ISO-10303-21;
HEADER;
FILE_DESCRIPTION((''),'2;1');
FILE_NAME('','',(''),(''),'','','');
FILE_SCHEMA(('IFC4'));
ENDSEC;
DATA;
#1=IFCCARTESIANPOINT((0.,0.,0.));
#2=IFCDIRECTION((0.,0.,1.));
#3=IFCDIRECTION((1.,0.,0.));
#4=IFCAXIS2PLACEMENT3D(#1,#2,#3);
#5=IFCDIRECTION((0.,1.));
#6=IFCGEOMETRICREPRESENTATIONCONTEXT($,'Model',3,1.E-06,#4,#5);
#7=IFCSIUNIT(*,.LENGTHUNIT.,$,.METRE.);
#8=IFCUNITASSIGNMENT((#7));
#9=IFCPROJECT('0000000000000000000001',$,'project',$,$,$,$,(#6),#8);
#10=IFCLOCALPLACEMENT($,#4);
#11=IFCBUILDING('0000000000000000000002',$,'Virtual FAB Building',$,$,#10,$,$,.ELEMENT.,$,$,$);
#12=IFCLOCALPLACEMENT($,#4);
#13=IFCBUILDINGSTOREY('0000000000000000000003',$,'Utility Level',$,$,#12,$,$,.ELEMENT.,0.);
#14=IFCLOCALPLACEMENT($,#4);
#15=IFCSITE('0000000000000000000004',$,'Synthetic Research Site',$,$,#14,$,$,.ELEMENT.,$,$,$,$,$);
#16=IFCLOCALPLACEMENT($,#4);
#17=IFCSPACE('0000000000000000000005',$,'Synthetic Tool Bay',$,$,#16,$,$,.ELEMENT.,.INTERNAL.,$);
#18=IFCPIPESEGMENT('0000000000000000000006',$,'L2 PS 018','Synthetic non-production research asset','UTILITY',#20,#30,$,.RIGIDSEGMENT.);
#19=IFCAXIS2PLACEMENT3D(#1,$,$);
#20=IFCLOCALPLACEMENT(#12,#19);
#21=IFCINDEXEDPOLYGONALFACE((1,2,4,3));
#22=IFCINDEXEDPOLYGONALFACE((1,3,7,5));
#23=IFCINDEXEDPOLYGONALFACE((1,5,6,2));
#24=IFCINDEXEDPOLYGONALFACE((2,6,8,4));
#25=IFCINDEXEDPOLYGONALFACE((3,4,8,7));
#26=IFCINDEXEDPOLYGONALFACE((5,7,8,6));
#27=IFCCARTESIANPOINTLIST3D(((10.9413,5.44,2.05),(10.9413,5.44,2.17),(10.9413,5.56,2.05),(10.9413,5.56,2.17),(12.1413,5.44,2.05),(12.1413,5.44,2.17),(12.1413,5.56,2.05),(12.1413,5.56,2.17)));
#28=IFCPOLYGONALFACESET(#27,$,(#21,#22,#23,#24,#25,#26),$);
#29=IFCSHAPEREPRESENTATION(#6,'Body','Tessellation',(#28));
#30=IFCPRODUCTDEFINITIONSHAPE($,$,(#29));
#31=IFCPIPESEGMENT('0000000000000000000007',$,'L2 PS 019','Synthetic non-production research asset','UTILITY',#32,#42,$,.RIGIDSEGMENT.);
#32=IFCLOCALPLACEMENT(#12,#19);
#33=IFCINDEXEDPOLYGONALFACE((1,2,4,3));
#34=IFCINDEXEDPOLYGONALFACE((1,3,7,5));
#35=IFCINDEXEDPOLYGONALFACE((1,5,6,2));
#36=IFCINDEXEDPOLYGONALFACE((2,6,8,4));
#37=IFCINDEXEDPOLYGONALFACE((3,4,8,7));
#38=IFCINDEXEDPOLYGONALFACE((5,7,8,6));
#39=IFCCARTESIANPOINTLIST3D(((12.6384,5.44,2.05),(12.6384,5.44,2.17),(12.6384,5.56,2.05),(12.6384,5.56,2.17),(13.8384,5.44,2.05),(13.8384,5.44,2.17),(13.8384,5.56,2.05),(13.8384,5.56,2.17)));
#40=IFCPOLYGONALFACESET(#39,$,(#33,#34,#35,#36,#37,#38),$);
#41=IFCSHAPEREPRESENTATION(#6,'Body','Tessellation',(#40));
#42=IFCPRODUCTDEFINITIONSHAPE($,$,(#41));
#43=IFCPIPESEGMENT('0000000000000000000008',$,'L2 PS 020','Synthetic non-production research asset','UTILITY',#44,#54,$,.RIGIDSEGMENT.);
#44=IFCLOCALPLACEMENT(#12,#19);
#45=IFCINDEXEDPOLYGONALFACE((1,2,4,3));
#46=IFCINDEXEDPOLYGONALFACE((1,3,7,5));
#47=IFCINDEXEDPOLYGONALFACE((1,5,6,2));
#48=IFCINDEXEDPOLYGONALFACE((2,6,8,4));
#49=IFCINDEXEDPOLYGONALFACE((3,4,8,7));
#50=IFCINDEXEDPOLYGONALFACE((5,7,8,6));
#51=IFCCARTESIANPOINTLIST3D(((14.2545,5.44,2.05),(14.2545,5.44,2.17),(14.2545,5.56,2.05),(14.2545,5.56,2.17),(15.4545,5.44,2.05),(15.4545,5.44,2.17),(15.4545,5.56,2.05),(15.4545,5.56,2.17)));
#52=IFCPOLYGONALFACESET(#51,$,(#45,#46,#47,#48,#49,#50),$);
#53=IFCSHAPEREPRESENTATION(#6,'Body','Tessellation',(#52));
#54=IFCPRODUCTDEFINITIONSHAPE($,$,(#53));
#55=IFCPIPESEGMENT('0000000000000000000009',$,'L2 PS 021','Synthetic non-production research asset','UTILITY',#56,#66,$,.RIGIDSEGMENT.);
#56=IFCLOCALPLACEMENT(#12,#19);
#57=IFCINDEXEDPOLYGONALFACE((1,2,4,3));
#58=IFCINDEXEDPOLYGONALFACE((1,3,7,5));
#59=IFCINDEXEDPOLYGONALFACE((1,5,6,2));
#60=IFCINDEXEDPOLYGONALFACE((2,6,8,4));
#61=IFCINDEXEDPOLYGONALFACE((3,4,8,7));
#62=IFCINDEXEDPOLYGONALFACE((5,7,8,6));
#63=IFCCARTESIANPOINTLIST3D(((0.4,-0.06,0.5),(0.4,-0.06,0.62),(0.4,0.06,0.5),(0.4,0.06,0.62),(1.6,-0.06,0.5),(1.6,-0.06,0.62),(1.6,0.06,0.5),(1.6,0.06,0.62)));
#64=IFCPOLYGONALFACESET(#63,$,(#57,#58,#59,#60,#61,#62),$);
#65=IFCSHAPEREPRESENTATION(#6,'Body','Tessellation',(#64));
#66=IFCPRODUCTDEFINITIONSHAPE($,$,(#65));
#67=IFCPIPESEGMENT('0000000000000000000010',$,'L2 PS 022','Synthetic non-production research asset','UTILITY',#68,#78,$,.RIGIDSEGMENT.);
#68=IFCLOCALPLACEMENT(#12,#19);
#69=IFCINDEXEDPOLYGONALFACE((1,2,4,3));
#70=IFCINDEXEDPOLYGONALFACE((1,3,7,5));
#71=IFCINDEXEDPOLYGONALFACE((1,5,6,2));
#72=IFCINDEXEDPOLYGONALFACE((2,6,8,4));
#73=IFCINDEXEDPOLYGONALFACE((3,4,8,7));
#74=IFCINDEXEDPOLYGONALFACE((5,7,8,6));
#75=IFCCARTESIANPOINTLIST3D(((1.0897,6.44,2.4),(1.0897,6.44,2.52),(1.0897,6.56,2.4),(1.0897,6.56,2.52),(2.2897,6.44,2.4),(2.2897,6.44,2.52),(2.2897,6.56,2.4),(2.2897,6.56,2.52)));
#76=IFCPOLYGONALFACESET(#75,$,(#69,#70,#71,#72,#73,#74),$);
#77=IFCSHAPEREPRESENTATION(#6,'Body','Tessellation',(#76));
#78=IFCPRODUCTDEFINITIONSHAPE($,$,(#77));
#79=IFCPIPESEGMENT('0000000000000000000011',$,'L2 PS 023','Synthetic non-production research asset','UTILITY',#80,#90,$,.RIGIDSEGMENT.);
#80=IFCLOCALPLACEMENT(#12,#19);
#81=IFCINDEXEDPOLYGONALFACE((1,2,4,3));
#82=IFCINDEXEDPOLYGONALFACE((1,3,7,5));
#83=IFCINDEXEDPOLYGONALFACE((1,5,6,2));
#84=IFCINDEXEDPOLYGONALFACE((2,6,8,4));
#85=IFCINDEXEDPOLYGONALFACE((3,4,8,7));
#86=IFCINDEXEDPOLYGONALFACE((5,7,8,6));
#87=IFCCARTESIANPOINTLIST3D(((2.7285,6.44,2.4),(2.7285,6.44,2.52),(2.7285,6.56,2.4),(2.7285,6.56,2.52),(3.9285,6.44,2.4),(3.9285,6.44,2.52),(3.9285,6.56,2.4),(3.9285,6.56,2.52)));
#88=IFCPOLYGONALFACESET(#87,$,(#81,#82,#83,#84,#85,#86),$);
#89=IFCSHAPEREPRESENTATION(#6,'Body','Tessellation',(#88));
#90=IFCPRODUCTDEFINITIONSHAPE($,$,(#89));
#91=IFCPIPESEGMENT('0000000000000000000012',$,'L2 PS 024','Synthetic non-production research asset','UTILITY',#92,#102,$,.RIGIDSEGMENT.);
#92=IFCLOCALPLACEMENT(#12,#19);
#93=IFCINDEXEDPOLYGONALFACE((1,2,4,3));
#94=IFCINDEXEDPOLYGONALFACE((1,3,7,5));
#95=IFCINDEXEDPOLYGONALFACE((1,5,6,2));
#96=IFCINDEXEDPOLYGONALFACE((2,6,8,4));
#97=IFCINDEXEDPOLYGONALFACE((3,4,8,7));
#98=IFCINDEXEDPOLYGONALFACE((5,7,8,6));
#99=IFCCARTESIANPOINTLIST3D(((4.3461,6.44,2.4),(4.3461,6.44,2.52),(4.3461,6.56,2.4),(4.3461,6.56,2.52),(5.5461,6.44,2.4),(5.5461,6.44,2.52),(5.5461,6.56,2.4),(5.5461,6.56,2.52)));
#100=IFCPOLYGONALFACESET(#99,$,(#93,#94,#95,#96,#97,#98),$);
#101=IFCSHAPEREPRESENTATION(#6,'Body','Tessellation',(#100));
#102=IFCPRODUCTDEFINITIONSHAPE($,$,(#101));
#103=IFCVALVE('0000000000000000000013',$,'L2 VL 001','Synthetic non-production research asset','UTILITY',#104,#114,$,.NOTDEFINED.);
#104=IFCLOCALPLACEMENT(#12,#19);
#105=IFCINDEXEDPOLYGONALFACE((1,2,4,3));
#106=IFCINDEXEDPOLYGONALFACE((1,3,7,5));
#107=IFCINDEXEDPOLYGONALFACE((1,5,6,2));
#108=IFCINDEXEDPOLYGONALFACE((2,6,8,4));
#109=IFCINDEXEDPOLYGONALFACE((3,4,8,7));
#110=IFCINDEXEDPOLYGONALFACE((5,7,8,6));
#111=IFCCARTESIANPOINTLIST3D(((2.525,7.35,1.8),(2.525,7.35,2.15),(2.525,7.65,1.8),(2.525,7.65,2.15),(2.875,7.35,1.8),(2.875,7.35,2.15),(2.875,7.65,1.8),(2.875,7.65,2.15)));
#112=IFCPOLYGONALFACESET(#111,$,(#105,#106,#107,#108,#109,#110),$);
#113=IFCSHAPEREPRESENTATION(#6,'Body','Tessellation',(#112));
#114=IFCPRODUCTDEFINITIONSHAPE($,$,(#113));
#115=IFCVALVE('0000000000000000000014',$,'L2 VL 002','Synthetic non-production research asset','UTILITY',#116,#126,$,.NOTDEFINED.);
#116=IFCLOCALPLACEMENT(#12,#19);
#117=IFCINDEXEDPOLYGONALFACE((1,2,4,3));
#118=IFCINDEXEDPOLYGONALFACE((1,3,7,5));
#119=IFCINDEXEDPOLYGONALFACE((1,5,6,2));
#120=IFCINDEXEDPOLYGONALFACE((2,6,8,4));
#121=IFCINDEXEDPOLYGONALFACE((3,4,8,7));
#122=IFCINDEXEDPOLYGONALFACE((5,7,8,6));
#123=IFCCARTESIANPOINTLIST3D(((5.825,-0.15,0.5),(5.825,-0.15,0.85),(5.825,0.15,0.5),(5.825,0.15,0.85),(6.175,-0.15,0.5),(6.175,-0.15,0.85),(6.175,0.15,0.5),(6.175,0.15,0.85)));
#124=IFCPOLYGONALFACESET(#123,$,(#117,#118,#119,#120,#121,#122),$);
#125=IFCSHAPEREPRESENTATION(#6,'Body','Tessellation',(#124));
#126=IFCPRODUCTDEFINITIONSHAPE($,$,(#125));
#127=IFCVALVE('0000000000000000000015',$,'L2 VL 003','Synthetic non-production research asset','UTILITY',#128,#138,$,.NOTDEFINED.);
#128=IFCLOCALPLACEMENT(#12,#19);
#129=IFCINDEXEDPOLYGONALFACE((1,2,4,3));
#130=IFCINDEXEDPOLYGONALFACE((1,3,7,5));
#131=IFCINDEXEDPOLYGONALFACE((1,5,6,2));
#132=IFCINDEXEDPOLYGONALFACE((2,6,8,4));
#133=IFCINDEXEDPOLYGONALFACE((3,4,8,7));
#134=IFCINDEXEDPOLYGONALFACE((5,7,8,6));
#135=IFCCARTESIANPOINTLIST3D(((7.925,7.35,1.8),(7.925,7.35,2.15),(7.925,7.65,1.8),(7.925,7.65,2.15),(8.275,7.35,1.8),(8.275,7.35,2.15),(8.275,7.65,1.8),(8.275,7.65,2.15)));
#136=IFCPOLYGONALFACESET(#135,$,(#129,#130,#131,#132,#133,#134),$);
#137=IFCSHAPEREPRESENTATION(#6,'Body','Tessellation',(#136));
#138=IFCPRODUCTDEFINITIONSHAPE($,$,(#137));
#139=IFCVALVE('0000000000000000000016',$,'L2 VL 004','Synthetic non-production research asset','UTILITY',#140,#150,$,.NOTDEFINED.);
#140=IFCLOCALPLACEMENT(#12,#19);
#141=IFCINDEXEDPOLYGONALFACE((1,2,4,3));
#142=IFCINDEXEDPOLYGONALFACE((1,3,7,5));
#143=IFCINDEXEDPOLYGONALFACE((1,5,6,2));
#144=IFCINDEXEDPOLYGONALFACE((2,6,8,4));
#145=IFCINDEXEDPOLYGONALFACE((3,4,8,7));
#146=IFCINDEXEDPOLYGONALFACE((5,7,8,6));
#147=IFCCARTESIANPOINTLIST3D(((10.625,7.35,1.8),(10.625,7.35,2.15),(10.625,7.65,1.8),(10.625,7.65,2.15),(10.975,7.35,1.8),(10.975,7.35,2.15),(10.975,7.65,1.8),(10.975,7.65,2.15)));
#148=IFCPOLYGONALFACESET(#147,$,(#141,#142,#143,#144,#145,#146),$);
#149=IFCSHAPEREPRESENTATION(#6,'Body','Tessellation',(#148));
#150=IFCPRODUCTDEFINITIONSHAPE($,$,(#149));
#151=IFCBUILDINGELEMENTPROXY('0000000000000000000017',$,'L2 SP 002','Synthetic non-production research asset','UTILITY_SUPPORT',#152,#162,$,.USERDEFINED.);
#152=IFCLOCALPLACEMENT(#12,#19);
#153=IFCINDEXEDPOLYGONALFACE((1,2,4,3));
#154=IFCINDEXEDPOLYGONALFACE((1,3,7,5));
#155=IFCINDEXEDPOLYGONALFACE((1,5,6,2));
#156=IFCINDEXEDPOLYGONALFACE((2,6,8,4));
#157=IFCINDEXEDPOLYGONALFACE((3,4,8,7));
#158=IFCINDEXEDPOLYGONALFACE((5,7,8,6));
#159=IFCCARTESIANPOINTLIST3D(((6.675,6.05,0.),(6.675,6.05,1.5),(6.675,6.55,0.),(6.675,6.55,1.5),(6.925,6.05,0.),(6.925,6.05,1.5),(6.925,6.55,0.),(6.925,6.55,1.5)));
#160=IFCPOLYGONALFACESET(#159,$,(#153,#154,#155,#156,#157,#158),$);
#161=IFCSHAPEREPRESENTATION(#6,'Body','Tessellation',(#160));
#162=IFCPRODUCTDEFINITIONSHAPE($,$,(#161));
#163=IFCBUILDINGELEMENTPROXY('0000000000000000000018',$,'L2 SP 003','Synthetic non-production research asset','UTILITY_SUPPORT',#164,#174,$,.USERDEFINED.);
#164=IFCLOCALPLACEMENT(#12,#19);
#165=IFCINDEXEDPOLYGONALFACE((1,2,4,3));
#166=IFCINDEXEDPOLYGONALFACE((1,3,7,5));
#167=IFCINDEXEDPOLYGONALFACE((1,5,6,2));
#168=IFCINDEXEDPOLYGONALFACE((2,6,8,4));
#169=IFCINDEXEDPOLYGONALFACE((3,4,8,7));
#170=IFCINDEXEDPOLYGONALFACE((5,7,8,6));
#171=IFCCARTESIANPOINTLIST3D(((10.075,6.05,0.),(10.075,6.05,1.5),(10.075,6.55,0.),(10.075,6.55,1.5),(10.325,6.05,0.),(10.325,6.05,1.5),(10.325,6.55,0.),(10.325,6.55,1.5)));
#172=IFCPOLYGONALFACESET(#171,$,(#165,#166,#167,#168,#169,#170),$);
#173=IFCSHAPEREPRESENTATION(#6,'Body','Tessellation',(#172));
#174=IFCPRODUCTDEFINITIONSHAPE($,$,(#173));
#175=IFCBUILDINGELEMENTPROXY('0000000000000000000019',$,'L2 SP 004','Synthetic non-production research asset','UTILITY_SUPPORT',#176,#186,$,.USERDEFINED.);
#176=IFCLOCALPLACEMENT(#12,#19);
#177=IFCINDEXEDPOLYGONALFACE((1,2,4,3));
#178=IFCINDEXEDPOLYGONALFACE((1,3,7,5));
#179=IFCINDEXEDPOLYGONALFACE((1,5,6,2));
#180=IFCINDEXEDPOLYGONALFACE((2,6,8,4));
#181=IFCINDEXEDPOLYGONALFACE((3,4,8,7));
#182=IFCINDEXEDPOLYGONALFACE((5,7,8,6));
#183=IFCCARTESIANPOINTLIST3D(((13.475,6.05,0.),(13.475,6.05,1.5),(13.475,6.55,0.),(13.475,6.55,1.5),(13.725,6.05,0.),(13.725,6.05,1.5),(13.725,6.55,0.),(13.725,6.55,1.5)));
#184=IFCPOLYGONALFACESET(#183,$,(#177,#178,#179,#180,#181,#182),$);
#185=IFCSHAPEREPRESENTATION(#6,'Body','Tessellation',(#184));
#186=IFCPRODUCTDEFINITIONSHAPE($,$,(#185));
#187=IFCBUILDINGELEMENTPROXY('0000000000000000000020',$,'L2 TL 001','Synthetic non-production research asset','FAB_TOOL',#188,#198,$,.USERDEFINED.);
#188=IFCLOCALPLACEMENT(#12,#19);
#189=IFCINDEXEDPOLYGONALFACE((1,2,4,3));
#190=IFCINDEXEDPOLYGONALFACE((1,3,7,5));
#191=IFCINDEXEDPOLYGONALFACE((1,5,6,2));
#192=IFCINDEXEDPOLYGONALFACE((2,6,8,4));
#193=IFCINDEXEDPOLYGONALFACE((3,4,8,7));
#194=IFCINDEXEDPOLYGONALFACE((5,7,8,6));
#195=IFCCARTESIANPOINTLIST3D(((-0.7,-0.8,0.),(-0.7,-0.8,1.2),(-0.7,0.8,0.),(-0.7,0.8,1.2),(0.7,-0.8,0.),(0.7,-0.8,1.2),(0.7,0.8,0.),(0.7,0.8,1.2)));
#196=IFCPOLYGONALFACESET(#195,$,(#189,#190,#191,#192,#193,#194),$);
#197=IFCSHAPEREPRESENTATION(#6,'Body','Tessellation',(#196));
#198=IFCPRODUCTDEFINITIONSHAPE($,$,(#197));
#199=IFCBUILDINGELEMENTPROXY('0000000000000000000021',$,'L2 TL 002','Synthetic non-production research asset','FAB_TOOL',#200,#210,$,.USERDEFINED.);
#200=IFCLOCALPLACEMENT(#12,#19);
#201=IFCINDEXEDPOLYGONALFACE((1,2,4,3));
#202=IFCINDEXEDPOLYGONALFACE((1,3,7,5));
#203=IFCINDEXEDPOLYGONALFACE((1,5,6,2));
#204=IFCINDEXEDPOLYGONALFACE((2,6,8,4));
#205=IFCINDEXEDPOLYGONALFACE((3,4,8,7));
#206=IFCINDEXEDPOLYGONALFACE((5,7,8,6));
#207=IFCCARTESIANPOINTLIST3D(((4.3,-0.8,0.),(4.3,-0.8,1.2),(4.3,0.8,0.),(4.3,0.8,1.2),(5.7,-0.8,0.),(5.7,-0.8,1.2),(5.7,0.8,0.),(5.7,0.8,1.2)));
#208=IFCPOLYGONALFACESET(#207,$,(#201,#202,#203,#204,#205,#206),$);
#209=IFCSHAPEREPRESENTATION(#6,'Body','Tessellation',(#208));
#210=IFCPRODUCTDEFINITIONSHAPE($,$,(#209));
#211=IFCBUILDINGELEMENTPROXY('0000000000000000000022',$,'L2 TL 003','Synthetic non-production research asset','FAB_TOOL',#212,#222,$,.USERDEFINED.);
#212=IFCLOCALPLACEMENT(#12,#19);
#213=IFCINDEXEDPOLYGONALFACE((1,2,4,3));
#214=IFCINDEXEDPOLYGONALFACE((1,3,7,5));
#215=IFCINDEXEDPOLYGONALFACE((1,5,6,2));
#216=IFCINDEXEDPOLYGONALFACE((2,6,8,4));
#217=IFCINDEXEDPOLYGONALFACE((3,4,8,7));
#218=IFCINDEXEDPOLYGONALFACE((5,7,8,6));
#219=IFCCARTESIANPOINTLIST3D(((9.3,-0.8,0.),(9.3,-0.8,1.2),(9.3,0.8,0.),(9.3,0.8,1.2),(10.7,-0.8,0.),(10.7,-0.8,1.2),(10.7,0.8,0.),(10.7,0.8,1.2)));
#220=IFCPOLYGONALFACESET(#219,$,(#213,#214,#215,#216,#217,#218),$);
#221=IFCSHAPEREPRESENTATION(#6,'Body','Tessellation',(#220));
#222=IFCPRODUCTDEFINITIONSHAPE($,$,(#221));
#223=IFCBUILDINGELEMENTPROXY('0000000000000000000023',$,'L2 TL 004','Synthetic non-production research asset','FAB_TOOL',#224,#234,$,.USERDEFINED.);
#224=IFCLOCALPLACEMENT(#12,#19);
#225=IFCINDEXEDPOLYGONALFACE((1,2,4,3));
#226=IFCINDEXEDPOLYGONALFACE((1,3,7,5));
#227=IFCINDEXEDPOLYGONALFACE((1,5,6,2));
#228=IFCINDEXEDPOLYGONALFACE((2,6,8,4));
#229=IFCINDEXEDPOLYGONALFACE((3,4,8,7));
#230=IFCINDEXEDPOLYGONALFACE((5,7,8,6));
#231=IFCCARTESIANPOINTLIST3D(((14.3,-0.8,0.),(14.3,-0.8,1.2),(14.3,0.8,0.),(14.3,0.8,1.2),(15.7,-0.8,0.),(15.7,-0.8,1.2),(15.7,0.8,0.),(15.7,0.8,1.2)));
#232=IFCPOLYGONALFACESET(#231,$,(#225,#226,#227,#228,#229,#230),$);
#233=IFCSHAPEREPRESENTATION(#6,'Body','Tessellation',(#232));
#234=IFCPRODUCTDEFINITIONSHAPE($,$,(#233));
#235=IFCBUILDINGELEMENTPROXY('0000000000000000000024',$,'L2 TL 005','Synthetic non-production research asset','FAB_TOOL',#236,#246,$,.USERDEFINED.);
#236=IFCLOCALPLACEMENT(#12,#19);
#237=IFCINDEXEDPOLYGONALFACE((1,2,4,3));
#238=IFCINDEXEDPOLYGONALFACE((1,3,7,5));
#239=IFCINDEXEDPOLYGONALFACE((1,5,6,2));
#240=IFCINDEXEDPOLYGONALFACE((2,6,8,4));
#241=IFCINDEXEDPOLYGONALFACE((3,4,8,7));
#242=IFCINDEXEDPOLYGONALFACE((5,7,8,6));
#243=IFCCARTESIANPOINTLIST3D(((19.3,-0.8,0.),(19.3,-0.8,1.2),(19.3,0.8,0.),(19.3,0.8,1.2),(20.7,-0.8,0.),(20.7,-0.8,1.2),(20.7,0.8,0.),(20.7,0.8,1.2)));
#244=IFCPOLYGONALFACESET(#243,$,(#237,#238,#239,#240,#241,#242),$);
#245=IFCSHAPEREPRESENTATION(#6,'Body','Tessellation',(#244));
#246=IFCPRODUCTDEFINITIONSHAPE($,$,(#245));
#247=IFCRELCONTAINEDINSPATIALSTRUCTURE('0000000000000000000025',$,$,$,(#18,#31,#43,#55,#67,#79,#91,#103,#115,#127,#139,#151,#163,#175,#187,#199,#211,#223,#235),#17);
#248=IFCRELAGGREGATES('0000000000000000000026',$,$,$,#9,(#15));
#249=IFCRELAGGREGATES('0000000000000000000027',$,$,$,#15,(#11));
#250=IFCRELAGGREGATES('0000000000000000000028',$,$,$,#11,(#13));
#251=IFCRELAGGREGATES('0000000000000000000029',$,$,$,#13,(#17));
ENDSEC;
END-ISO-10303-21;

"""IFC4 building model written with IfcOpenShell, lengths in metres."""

from ifc_helpers import new_model, si_unit, direction, frame, origin_with_axes, origin_2d_with_axis, place, context, project, spatial, rectangle, extrude, element, save


model = new_model("IFC4")

# Units and contexts
model_context = context("Model", 3, precision=1e-06, world=origin_with_axes(), true_north=direction((0.0, 1.0)))
ifc_project = project(units=[si_unit("LENGTHUNIT", "METRE")], contexts=[model_context])

# Site, building, storey, space
site_placement = place(None, origin_with_axes())
site = spatial("IfcSite", under=ifc_project, at=site_placement, Name="Synthetic Research Site", CompositionType="ELEMENT")
building_placement = place(None, origin_with_axes())
building = spatial("IfcBuilding", under=site, at=building_placement, Name="Virtual FAB Building", CompositionType="ELEMENT")
storey_placement = place(None, origin_with_axes())
storey = spatial("IfcBuildingStorey", under=building, at=storey_placement, Name="Utility Level", CompositionType="ELEMENT", Elevation=0.0)
space_placement = place(None, origin_with_axes())
space = spatial("IfcSpace", under=storey, at=space_placement, Name="Synthetic Tool Bay", CompositionType="ELEMENT", PredefinedType="INTERNAL")

# Pipe segments
for number, where, z_axis, x_axis, name in (
    (1, (11.5413, 5.5, 2.05), (0.0, 0.0, 1.0), (1.0, 0.0, 0.0), "L2 PS 018"),
    (2, (13.2384, 5.5, 2.05), (0.0, 0.0, 1.0), (1.0, 0.0, 0.0), "L2 PS 019"),
    (3, (14.8545, 5.5, 2.05), (0.0, 0.0, 1.0), (1.0, 0.0, 0.0), "L2 PS 020"),
    (4, (1.0, 0.0, 0.5), (0.0, 0.0, 1.0), (1.0, 0.0, 0.0), "L2 PS 021"),
    (5, (1.6897, 6.5, 2.4), (0.0, 0.0, 1.0), (1.0, 0.0, 0.0), "L2 PS 022"),
    (6, (3.3285, 6.5, 2.4), (0.0, 0.0, 1.0), (1.0, 0.0, 0.0), "L2 PS 023"),
    (7, (4.9461, 6.5, 2.4), (0.0, 0.0, 1.0), (1.0, 0.0, 0.0), "L2 PS 024"),
):
    element("IfcPipeSegment", number, at=place(None, frame(where, z_axis=z_axis, x_axis=x_axis)), inside=space, Name=name, Description="Synthetic non-production research asset", ObjectType="UTILITY", PredefinedType="RIGIDSEGMENT", context=model_context, shape_type="SweptSolid", body=[
        extrude(rectangle(XDim=1.2, YDim=0.12, at=origin_2d_with_axis()), origin_with_axes(), (0.0, 0.0, 1.0), 0.12),
    ])

# Valves
for number, where, z_axis, x_axis, name in (
    (8, (2.7, 7.5, 1.8), (0.0, 0.0, 1.0), (1.0, 0.0, 0.0), "L2 VL 001"),
    (9, (6.0, 0.0, 0.5), (0.0, 0.0, 1.0), (1.0, 0.0, 0.0), "L2 VL 002"),
    (10, (8.1, 7.5, 1.8), (0.0, 0.0, 1.0), (1.0, 0.0, 0.0), "L2 VL 003"),
    (11, (10.8, 7.5, 1.8), (0.0, 0.0, 1.0), (1.0, 0.0, 0.0), "L2 VL 004"),
):
    element("IfcValve", number, at=place(None, frame(where, z_axis=z_axis, x_axis=x_axis)), inside=space, Name=name, Description="Synthetic non-production research asset", ObjectType="UTILITY", PredefinedType="NOTDEFINED", context=model_context, shape_type="SweptSolid", body=[
        extrude(rectangle(XDim=0.35, YDim=0.3, at=origin_2d_with_axis()), origin_with_axes(), (0.0, 0.0, 1.0), 0.35),
    ])

# Building element proxies
for number, where, z_axis, x_axis, name in (
    (12, (6.8, 6.3, 0.0), (0.0, 0.0, 1.0), (1.0, 0.0, 0.0), "L2 SP 002"),
    (13, (10.2, 6.3, 0.0), (0.0, 0.0, 1.0), (1.0, 0.0, 0.0), "L2 SP 003"),
    (14, (13.6, 6.3, 0.0), (0.0, 0.0, 1.0), (1.0, 0.0, 0.0), "L2 SP 004"),
):
    element("IfcBuildingElementProxy", number, at=place(None, frame(where, z_axis=z_axis, x_axis=x_axis)), inside=space, Name=name, Description="Synthetic non-production research asset", ObjectType="UTILITY_SUPPORT", PredefinedType="USERDEFINED", context=model_context, shape_type="SweptSolid", body=[
        extrude(rectangle(XDim=0.25, YDim=0.5, at=origin_2d_with_axis()), origin_with_axes(), (0.0, 0.0, 1.0), 1.5),
    ])
for number, where, z_axis, x_axis, name in (
    (15, (0.0, 0.0, 0.0), (0.0, 0.0, 1.0), (1.0, 0.0, 0.0), "L2 TL 001"),
    (16, (5.0, 0.0, 0.0), (0.0, 0.0, 1.0), (1.0, 0.0, 0.0), "L2 TL 002"),
    (17, (10.0, 0.0, 0.0), (0.0, 0.0, 1.0), (1.0, 0.0, 0.0), "L2 TL 003"),
    (18, (15.0, 0.0, 0.0), (0.0, 0.0, 1.0), (1.0, 0.0, 0.0), "L2 TL 004"),
    (19, (20.0, 0.0, 0.0), (0.0, 0.0, 1.0), (1.0, 0.0, 0.0), "L2 TL 005"),
):
    element("IfcBuildingElementProxy", number, at=place(None, frame(where, z_axis=z_axis, x_axis=x_axis)), inside=space, Name=name, Description="Synthetic non-production research asset", ObjectType="FAB_TOOL", PredefinedType="USERDEFINED", context=model_context, shape_type="SweptSolid", body=[
        extrude(rectangle(XDim=1.4, YDim=1.6, at=origin_2d_with_axis()), origin_with_axes(), (0.0, 0.0, 1.0), 1.2),
    ])

save(model, "model.ifc")
